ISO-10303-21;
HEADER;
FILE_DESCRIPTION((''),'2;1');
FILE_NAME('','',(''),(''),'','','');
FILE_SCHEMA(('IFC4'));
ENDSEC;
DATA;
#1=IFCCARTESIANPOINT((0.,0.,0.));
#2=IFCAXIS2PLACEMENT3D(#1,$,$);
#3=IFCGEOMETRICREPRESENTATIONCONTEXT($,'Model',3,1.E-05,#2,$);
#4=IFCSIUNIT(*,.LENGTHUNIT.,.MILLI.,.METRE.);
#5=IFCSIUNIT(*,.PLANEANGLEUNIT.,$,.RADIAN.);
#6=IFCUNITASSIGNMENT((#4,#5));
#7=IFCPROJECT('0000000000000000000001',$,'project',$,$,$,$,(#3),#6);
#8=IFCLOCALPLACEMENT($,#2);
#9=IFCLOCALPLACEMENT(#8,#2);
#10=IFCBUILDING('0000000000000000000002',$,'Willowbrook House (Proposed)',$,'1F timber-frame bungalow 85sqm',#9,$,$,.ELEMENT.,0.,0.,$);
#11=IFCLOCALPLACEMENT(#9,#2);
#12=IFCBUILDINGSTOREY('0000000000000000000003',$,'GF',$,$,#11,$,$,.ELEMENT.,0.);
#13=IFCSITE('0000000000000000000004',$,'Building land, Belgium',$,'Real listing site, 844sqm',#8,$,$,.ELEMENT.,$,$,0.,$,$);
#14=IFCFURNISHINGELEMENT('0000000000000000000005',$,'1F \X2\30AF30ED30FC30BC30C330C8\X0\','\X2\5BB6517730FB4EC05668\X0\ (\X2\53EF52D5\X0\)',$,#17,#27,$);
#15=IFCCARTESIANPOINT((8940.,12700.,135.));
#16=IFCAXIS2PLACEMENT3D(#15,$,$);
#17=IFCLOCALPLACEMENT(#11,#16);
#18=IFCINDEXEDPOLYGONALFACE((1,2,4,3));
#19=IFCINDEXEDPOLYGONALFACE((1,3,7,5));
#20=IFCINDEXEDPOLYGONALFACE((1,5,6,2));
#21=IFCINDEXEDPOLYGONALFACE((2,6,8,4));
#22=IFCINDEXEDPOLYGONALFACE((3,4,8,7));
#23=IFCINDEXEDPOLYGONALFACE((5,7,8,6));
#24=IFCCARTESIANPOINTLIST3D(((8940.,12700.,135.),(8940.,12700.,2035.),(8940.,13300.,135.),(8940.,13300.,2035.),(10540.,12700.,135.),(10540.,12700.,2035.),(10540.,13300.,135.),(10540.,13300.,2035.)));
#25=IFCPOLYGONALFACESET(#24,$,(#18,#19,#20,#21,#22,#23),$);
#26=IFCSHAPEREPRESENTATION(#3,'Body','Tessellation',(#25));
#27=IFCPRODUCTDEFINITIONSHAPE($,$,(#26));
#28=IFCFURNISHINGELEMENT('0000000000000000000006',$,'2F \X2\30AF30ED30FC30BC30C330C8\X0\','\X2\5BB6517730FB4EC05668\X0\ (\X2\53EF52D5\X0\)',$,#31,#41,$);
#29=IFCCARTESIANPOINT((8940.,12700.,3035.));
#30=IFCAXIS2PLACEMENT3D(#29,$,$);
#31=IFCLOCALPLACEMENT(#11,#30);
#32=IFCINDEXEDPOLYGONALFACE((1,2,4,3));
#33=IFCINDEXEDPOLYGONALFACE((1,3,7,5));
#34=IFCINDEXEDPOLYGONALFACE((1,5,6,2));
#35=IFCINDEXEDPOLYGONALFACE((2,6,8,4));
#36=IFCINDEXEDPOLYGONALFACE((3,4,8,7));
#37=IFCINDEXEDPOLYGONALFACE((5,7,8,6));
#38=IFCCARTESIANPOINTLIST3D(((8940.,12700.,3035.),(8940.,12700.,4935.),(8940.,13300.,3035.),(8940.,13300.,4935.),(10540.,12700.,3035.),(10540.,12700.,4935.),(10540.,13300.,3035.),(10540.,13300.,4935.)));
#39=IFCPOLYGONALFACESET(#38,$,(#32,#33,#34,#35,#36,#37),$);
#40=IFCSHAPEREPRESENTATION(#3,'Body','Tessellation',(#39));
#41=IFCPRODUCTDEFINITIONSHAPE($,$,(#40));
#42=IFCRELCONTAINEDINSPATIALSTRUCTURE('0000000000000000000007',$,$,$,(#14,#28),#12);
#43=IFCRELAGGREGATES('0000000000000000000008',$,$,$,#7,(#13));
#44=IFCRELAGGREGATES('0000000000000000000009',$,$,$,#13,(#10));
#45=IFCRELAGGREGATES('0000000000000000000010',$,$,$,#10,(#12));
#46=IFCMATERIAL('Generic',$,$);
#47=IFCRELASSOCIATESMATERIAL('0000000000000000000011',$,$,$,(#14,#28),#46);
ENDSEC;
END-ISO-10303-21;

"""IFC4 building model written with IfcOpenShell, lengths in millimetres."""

from ifc_helpers import new_model, si_unit, frame, frame_2d, origin, place, context, project, spatial, rectangle, extrude, material, element, save


model = new_model("IFC4")

# Units and contexts
model_context = context("Model", 3, precision=1e-05, world=origin())
ifc_project = project(units=[si_unit("LENGTHUNIT", "METRE", prefix="MILLI"), si_unit("PLANEANGLEUNIT", "RADIAN")], contexts=[model_context])

# Site, building, storey
site_placement = place(None, origin())
site = spatial("IfcSite", under=ifc_project, at=site_placement, Name="Building land, Belgium", ObjectType="Real listing site, 844sqm", CompositionType="ELEMENT", RefElevation=0.0)
building_placement = place(site_placement, origin())
building = spatial("IfcBuilding", under=site, at=building_placement, Name="Willowbrook House (Proposed)", ObjectType="1F timber-frame bungalow 85sqm", CompositionType="ELEMENT", ElevationOfRefHeight=0.0, ElevationOfTerrain=0.0)
storey_placement = place(building_placement, origin())
storey = spatial("IfcBuildingStorey", under=building, at=storey_placement, Name="GF", CompositionType="ELEMENT", Elevation=0.0)

# Shared definitions
ifc_material_1 = material(Name="Generic")

# Furnishing elements
furnishing_1_placement = place(storey_placement, frame((8940.0, 12700.0, 135.0)))
element("IfcFurnishingElement", 1, at=furnishing_1_placement, inside=storey, material=ifc_material_1, Name="1F クローゼット", Description="家具・什器 (可動)", context=model_context, shape_type="SweptSolid", body=[
    extrude(rectangle(XDim=1600.0, YDim=600.0, at=frame_2d((800.0, 300.0))), frame((8940.0, 12700.0, 135.0)), (0.0, 0.0, 1.0), 1900.0),
])
furnishing_2_placement = place(storey_placement, frame((8940.0, 12700.0, 3035.0)))
element("IfcFurnishingElement", 2, at=furnishing_2_placement, inside=storey, material=ifc_material_1, Name="2F クローゼット", Description="家具・什器 (可動)", context=model_context, shape_type="SweptSolid", body=[
    extrude(rectangle(XDim=1600.0, YDim=600.0, at=frame_2d((800.0, 300.0))), frame((8940.0, 12700.0, 3035.0)), (0.0, 0.0, 1.0), 1900.0),
])

save(model, "model.ifc")
